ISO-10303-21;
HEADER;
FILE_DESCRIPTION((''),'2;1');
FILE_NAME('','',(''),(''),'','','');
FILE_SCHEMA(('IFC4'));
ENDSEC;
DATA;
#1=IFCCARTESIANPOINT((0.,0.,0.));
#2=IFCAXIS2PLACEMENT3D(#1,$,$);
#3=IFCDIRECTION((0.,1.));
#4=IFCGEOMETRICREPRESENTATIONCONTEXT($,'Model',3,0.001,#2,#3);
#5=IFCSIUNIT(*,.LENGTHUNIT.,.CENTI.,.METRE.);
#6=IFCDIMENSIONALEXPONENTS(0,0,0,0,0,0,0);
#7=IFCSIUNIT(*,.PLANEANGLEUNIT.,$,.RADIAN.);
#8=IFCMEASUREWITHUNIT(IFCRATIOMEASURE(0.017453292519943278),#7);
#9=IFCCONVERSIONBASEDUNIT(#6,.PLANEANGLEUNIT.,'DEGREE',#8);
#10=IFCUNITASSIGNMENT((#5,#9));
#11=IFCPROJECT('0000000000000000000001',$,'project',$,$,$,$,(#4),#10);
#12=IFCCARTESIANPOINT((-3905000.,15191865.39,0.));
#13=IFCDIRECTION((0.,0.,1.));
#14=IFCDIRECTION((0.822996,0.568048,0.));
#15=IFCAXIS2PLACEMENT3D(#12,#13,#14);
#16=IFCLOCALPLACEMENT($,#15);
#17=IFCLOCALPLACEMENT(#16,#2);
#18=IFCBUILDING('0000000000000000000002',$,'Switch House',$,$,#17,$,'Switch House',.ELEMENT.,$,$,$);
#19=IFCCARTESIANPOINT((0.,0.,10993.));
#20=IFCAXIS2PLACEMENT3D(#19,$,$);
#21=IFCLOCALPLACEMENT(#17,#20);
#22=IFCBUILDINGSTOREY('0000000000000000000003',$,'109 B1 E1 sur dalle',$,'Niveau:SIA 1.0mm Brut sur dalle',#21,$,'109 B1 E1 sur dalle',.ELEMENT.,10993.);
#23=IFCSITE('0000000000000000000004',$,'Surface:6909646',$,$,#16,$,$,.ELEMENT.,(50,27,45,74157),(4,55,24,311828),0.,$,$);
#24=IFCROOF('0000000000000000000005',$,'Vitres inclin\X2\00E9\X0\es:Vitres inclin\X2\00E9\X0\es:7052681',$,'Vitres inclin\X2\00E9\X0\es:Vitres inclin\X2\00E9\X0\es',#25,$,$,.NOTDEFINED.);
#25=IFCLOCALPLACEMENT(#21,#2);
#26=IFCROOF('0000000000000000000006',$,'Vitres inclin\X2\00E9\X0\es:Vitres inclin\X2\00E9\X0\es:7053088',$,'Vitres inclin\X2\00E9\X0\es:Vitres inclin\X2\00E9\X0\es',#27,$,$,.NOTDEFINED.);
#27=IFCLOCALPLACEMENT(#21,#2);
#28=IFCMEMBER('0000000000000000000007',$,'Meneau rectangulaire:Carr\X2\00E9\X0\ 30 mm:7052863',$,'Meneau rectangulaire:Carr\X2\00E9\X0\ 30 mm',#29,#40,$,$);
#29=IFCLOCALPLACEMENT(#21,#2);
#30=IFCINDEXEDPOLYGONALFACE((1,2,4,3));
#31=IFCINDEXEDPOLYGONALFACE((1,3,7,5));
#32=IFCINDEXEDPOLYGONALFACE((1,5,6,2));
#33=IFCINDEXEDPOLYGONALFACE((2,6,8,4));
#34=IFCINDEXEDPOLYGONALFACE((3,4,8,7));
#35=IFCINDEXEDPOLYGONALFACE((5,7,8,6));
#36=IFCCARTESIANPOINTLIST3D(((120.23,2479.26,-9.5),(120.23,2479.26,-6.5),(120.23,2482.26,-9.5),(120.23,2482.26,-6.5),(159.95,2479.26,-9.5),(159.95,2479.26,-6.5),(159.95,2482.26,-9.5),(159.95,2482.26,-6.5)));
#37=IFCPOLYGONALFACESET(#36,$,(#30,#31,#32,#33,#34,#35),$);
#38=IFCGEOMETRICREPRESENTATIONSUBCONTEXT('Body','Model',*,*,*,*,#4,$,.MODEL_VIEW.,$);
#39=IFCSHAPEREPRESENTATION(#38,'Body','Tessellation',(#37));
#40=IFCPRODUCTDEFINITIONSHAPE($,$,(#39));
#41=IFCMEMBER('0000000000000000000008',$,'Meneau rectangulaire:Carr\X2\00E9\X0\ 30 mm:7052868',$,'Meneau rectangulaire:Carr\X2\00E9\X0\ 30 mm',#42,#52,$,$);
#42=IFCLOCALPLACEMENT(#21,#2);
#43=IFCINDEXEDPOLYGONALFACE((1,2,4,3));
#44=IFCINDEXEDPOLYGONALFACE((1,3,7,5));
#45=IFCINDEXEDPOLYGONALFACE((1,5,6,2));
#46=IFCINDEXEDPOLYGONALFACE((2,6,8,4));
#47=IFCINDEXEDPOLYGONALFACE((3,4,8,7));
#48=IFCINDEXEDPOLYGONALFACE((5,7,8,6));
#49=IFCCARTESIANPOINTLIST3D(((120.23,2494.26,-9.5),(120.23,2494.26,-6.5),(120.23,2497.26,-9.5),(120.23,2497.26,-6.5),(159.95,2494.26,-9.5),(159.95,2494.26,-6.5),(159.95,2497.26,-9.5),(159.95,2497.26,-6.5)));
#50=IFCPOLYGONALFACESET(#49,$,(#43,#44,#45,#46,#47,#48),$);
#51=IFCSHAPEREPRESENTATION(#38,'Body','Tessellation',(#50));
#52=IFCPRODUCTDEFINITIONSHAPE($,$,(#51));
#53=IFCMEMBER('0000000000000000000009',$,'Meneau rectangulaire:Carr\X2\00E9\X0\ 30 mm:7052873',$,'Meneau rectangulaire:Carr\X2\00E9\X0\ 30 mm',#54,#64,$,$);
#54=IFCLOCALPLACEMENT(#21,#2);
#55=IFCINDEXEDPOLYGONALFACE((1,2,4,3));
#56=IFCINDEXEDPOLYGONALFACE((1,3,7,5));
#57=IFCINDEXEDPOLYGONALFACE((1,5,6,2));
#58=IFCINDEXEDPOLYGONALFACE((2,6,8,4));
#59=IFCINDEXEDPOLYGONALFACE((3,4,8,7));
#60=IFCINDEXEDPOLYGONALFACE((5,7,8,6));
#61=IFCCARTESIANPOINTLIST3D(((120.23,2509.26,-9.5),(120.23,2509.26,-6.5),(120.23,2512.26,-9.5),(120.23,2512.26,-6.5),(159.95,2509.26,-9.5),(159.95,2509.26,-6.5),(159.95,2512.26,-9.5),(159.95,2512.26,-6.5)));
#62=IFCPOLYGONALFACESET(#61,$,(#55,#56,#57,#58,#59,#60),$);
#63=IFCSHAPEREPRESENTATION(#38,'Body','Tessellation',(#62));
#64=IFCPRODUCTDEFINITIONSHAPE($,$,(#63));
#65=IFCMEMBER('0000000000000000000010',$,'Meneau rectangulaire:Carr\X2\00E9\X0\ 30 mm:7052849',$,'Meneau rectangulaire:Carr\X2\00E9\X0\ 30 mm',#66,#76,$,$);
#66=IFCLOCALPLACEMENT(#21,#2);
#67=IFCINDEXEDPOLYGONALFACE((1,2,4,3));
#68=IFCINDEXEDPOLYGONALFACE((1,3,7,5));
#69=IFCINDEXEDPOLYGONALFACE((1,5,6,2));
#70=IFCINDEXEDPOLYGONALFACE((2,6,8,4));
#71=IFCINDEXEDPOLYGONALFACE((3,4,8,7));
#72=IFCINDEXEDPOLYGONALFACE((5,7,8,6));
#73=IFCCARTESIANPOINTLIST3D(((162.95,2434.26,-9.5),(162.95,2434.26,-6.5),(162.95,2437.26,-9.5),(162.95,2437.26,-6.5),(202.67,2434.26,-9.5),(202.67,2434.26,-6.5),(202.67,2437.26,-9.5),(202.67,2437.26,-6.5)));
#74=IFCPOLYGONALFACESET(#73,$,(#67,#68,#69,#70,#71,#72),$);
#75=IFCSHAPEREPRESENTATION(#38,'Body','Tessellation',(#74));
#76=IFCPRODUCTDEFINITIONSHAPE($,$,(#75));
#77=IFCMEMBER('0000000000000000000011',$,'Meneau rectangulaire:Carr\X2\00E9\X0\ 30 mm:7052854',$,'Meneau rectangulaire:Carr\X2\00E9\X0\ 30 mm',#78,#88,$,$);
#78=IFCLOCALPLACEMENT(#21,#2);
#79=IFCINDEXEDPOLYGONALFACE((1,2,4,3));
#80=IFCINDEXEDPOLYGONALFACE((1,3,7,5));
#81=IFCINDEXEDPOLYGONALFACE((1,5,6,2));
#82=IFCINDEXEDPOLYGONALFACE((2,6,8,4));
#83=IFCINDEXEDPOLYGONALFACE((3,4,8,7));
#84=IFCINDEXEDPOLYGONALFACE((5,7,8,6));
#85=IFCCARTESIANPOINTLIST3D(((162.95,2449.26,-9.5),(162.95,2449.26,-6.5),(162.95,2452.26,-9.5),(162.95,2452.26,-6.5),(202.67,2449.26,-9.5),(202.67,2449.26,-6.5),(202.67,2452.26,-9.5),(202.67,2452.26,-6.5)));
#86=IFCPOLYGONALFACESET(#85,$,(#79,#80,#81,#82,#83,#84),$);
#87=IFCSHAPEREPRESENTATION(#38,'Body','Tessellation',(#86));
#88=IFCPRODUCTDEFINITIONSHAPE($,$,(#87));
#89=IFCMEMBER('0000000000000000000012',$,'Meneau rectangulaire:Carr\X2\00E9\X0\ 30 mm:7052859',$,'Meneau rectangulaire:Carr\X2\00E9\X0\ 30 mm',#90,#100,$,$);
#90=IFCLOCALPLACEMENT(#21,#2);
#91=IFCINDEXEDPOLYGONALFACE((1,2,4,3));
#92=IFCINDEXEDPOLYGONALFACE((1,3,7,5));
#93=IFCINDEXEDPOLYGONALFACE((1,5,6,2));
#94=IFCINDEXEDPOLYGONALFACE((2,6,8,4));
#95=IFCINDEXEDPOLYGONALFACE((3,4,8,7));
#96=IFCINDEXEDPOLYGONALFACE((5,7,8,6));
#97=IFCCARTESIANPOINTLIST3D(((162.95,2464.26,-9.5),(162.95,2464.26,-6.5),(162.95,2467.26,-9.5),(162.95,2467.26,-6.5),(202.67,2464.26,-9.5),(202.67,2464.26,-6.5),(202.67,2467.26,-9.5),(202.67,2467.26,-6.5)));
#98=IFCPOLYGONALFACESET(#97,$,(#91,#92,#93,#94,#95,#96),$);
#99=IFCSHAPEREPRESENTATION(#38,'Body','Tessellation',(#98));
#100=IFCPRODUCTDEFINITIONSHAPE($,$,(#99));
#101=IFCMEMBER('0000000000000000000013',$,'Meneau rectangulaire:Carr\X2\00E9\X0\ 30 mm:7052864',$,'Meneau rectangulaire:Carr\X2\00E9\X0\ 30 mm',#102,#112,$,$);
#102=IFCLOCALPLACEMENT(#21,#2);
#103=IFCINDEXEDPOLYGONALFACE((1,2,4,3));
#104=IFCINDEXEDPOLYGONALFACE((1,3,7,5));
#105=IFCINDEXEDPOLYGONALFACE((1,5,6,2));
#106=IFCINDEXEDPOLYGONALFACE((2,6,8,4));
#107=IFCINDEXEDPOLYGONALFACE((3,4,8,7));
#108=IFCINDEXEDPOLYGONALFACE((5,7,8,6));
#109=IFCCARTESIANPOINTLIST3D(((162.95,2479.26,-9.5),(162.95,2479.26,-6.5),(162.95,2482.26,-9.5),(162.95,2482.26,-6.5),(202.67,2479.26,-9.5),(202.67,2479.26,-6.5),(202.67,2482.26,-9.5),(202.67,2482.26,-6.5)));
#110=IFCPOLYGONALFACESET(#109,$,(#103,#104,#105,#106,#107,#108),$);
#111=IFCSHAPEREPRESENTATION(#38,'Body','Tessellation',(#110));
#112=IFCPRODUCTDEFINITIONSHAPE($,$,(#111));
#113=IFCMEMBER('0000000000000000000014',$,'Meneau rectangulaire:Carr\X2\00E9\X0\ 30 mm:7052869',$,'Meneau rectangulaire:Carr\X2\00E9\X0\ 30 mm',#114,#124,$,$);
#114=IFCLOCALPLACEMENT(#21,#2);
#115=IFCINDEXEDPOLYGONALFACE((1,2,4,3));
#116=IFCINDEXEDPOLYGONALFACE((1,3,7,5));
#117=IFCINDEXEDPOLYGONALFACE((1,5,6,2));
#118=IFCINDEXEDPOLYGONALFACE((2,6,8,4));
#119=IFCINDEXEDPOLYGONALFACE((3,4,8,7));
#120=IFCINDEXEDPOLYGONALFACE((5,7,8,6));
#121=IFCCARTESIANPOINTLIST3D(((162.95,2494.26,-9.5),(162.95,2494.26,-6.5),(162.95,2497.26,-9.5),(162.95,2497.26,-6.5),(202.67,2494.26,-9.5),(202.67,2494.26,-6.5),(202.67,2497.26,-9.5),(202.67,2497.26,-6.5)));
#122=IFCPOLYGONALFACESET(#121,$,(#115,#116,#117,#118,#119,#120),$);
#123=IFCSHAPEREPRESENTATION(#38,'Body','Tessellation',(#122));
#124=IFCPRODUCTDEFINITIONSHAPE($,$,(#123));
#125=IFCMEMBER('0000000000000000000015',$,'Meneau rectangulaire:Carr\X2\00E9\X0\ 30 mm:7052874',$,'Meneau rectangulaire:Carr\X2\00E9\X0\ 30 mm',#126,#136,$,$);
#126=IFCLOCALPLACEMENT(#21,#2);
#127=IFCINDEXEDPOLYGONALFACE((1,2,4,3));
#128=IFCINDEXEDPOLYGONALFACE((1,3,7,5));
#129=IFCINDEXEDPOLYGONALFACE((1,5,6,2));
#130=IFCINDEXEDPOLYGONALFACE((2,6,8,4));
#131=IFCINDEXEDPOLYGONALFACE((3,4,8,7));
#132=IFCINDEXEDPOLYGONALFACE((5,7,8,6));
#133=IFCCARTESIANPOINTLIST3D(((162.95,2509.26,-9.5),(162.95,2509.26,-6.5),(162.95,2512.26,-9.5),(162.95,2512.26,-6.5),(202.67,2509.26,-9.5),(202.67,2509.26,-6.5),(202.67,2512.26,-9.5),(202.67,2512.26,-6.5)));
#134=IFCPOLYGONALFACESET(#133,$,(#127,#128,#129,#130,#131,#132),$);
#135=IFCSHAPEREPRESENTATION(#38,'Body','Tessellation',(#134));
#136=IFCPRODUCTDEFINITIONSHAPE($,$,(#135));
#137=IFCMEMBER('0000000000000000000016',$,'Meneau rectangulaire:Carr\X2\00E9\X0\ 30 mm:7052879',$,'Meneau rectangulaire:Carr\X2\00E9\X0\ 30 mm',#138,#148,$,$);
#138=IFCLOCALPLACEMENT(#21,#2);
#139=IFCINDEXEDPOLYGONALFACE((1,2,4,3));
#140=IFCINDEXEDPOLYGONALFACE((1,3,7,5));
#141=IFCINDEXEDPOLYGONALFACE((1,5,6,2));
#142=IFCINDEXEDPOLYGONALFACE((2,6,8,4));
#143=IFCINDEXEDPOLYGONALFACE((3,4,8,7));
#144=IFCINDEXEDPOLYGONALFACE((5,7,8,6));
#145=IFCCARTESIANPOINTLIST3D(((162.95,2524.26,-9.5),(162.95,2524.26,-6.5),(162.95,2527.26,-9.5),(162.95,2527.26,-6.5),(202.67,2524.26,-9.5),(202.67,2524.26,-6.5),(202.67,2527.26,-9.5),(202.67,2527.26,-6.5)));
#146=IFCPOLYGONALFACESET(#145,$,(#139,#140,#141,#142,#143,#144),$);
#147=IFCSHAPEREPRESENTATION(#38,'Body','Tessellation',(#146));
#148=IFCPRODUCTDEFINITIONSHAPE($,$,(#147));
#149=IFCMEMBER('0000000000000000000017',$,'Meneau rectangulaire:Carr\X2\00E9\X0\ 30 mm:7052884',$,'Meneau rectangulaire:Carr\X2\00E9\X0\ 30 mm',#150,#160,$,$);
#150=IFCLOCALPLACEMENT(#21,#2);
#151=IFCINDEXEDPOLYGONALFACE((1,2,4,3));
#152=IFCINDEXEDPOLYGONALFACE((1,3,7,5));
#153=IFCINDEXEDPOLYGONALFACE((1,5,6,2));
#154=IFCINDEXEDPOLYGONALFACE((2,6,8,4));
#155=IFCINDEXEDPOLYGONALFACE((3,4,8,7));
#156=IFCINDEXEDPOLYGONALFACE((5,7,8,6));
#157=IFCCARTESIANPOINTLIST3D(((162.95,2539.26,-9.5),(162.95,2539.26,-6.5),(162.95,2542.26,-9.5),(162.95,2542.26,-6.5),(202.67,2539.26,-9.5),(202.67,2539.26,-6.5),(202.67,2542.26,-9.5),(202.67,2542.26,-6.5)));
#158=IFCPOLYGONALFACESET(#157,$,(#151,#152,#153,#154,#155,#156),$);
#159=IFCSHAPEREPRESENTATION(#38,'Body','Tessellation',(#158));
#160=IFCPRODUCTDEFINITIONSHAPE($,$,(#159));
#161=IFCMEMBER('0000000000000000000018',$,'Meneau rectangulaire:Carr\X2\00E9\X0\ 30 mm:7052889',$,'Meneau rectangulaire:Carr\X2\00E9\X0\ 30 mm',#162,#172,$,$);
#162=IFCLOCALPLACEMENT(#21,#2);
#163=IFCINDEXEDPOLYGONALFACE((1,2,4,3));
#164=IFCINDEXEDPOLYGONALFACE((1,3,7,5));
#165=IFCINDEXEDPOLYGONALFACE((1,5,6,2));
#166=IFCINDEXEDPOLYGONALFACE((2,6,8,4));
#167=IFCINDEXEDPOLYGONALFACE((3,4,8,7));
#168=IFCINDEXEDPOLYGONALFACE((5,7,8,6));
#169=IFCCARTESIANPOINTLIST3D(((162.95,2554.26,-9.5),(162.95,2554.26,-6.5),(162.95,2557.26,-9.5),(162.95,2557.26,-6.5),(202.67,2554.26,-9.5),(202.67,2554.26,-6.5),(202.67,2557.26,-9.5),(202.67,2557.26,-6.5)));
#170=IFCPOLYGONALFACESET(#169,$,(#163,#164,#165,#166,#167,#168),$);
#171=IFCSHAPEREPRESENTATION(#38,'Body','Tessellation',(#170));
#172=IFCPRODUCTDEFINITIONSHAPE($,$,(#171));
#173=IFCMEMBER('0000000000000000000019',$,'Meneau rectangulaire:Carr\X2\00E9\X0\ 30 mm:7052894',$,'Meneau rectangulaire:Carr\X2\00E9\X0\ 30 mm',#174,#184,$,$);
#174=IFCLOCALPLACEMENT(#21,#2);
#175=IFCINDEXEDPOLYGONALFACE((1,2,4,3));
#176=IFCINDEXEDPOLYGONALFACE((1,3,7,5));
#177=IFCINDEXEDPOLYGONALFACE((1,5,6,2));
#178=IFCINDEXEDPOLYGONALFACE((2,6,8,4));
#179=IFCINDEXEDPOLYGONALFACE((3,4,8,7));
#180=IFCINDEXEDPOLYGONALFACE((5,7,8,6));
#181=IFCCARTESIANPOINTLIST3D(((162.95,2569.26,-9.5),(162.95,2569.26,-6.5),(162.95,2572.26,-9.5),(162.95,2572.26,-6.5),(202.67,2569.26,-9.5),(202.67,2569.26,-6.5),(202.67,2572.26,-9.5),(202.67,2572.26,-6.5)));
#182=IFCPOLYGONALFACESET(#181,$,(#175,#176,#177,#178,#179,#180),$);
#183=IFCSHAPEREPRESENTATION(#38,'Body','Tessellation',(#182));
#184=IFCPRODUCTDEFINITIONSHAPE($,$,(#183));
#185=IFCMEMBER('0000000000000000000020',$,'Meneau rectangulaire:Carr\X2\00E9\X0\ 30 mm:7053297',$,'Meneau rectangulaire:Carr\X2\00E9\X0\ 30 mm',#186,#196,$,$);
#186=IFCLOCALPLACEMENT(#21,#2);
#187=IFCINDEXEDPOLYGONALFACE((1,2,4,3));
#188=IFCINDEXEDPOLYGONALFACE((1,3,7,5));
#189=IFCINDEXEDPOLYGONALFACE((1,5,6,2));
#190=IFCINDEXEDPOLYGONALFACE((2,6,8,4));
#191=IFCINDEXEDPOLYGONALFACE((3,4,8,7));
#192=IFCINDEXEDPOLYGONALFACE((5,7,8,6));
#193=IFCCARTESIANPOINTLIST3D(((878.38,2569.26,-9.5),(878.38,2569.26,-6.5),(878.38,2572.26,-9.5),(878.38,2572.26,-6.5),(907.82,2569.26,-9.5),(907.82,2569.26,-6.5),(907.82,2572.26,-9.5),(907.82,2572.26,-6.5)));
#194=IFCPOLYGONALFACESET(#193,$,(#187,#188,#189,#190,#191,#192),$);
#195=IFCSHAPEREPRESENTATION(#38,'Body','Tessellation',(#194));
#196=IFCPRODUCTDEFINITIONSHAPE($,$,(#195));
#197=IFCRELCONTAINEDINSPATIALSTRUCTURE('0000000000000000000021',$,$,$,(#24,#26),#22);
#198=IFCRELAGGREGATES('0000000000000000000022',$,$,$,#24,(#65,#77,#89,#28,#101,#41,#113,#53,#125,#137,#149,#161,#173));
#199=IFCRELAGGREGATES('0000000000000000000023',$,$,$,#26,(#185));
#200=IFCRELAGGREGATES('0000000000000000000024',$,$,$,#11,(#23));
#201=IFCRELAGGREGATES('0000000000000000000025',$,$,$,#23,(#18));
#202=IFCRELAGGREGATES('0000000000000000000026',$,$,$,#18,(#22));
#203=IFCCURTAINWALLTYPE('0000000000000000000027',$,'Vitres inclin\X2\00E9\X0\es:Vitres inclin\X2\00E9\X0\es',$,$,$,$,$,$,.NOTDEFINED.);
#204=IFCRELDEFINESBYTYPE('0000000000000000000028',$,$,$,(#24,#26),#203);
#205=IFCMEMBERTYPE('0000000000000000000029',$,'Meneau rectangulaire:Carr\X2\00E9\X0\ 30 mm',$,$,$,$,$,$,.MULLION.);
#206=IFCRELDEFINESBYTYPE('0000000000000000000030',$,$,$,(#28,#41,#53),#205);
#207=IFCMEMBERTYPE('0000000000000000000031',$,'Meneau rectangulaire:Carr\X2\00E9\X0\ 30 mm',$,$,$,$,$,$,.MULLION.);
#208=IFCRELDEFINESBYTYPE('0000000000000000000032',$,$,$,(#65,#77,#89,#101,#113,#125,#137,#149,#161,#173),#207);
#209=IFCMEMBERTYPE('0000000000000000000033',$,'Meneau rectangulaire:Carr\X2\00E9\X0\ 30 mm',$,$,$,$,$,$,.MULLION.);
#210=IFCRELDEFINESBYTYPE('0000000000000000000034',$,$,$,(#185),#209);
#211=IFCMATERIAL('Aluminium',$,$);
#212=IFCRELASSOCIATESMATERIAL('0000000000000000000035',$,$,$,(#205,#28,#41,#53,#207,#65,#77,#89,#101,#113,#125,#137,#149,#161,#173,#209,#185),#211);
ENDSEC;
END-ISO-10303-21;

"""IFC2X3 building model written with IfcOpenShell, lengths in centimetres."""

from ifc_helpers import new_model, entity, si_unit, converted_unit, direction, frame, origin, origin_2d_with_axis, place, context, subcontext, project, spatial, rectangle, extrude, source, transform, mapped, material, type_object, type_shapes, element, aggregate, save


model = new_model("IFC2X3")

# Units and contexts
model_context = context("Model", 3, precision=0.001, world=origin(), true_north=direction((0.0, 1.0)))
body_context = subcontext(model_context, "Body", "Model", "MODEL_VIEW")
ifc_project = project(units=[si_unit("LENGTHUNIT", "METRE", prefix="CENTI"), converted_unit("PLANEANGLEUNIT", "DEGREE", entity("IfcRatioMeasure", 0.017453292519943278), si_unit("PLANEANGLEUNIT", "RADIAN"), dimensions=[0, 0, 0, 0, 0, 0, 0])], contexts=[model_context])

# Site, building, storey
site_placement = place(None, frame((-3905000.0, 15191865.39, 0.0), z_axis=(0.0, 0.0, 1.0), x_axis=(0.822996, 0.568048, 0.0)))
site = spatial("IfcSite", under=ifc_project, at=site_placement, Name="Surface:6909646", CompositionType="ELEMENT", RefLatitude=(50, 27, 45, 74157), RefLongitude=(4, 55, 24, 311828), RefElevation=0.0)
building_placement = place(site_placement, origin())
building = spatial("IfcBuilding", under=site, at=building_placement, Name="Switch House", LongName="Switch House", CompositionType="ELEMENT")
storey_placement = place(building_placement, frame((0.0, 0.0, 10993.0)))
storey = spatial("IfcBuildingStorey", under=building, at=storey_placement, Name="109 B1 E1 sur dalle", ObjectType="Niveau:SIA 1.0mm Brut sur dalle", LongName="109 B1 E1 sur dalle", CompositionType="ELEMENT", Elevation=10993.0)

# Roofs
curtain_wall_type = type_object("IfcCurtainWallType", Name="Vitres inclinées:Vitres inclinées", PredefinedType="NOTDEFINED")
roof_1_placement = place(storey_placement, frame((0.0, 0.0, -10993.0)))
roof_1 = element("IfcRoof", 1, at=roof_1_placement, inside=storey, type_object=curtain_wall_type, Name="Vitres inclinées:Vitres inclinées:7052681", ObjectType="Vitres inclinées:Vitres inclinées", ShapeType="NOTDEFINED")
ifc_material = material(Name="Aluminium")
roof_2_placement = place(storey_placement, frame((0.0, 0.0, -10993.0)))
roof_2 = element("IfcRoof", 2, at=roof_2_placement, inside=storey, type_object=curtain_wall_type, Name="Vitres inclinées:Vitres inclinées:7053088", ObjectType="Vitres inclinées:Vitres inclinées", ShapeType="NOTDEFINED")

# Members
member_type_1 = type_object("IfcMemberType", Name="Meneau rectangulaire:Carré 30 mm", PredefinedType="MULLION", material=ifc_material)
shared_shape_1 = source(origin(), body_context, "Body", "SweptSolid", [
    extrude(rectangle(XDim=3.0, YDim=3.0, at=origin_2d_with_axis()), frame((0.0, 0.0, -39.72), z_axis=(0.0, 0.0, 1.0), x_axis=(0.0, -1.0, 0.0)), (0.0, 0.0, 1.0), 39.72),
])
type_shapes(member_type_1, [shared_shape_1])
member_1_placement = place(roof_1_placement, frame((120.23, 2480.76, 10985.0), z_axis=(-1.0, 0.0, 0.0), x_axis=(0.0, 1.0, 0.0)))
member_1 = element("IfcMember", 3, at=member_1_placement, type_object=member_type_1, material=ifc_material, Name="Meneau rectangulaire:Carré 30 mm:7052863", ObjectType="Meneau rectangulaire:Carré 30 mm", context=body_context, shape_type="MappedRepresentation", body=[
    mapped(shared_shape_1, transform((0.0, 0.0, 0.0), scale=1.0)),
])
member_2_placement = place(roof_1_placement, frame((120.23, 2495.76, 10985.0), z_axis=(-1.0, 0.0, 0.0), x_axis=(0.0, 1.0, 0.0)))
member_2 = element("IfcMember", 4, at=member_2_placement, type_object=member_type_1, material=ifc_material, Name="Meneau rectangulaire:Carré 30 mm:7052868", ObjectType="Meneau rectangulaire:Carré 30 mm", context=body_context, shape_type="MappedRepresentation", body=[
    mapped(shared_shape_1, transform((0.0, 0.0, 0.0), scale=1.0)),
])
member_3_placement = place(roof_1_placement, frame((120.23, 2510.76, 10985.0), z_axis=(-1.0, 0.0, 0.0), x_axis=(0.0, 1.0, 0.0)))
member_3 = element("IfcMember", 5, at=member_3_placement, type_object=member_type_1, material=ifc_material, Name="Meneau rectangulaire:Carré 30 mm:7052873", ObjectType="Meneau rectangulaire:Carré 30 mm", context=body_context, shape_type="MappedRepresentation", body=[
    mapped(shared_shape_1, transform((0.0, 0.0, 0.0), scale=1.0)),
])
member_type_2 = type_object("IfcMemberType", Name="Meneau rectangulaire:Carré 30 mm", PredefinedType="MULLION", material=ifc_material)
shared_shape_2 = source(origin(), body_context, "Body", "SweptSolid", [
    extrude(rectangle(XDim=3.0, YDim=3.0, at=origin_2d_with_axis()), frame((0.0, 0.0, -39.72), z_axis=(0.0, 0.0, 1.0), x_axis=(0.0, -1.0, 0.0)), (0.0, 0.0, 1.0), 39.72),
])
type_shapes(member_type_2, [shared_shape_2])
member_4_placement = place(roof_1_placement, frame((162.95, 2435.76, 10985.0), z_axis=(-1.0, 0.0, 0.0), x_axis=(0.0, 1.0, 0.0)))
member_4 = element("IfcMember", 6, at=member_4_placement, type_object=member_type_2, material=ifc_material, Name="Meneau rectangulaire:Carré 30 mm:7052849", ObjectType="Meneau rectangulaire:Carré 30 mm", context=body_context, shape_type="MappedRepresentation", body=[
    mapped(shared_shape_2, transform((0.0, 0.0, 0.0), scale=1.0)),
])
member_5_placement = place(roof_1_placement, frame((162.95, 2450.76, 10985.0), z_axis=(-1.0, 0.0, 0.0), x_axis=(0.0, 1.0, 0.0)))
member_5 = element("IfcMember", 7, at=member_5_placement, type_object=member_type_2, material=ifc_material, Name="Meneau rectangulaire:Carré 30 mm:7052854", ObjectType="Meneau rectangulaire:Carré 30 mm", context=body_context, shape_type="MappedRepresentation", body=[
    mapped(shared_shape_2, transform((0.0, 0.0, 0.0), scale=1.0)),
])
member_6_placement = place(roof_1_placement, frame((162.95, 2465.76, 10985.0), z_axis=(-1.0, 0.0, 0.0), x_axis=(0.0, 1.0, 0.0)))
member_6 = element("IfcMember", 8, at=member_6_placement, type_object=member_type_2, material=ifc_material, Name="Meneau rectangulaire:Carré 30 mm:7052859", ObjectType="Meneau rectangulaire:Carré 30 mm", context=body_context, shape_type="MappedRepresentation", body=[
    mapped(shared_shape_2, transform((0.0, 0.0, 0.0), scale=1.0)),
])
member_7_placement = place(roof_1_placement, frame((162.95, 2480.76, 10985.0), z_axis=(-1.0, 0.0, 0.0), x_axis=(0.0, 1.0, 0.0)))
member_7 = element("IfcMember", 9, at=member_7_placement, type_object=member_type_2, material=ifc_material, Name="Meneau rectangulaire:Carré 30 mm:7052864", ObjectType="Meneau rectangulaire:Carré 30 mm", context=body_context, shape_type="MappedRepresentation", body=[
    mapped(shared_shape_2, transform((0.0, 0.0, 0.0), scale=1.0)),
])
member_8_placement = place(roof_1_placement, frame((162.95, 2495.76, 10985.0), z_axis=(-1.0, 0.0, 0.0), x_axis=(0.0, 1.0, 0.0)))
member_8 = element("IfcMember", 10, at=member_8_placement, type_object=member_type_2, material=ifc_material, Name="Meneau rectangulaire:Carré 30 mm:7052869", ObjectType="Meneau rectangulaire:Carré 30 mm", context=body_context, shape_type="MappedRepresentation", body=[
    mapped(shared_shape_2, transform((0.0, 0.0, 0.0), scale=1.0)),
])
member_9_placement = place(roof_1_placement, frame((162.95, 2510.76, 10985.0), z_axis=(-1.0, 0.0, 0.0), x_axis=(0.0, 1.0, 0.0)))
member_9 = element("IfcMember", 11, at=member_9_placement, type_object=member_type_2, material=ifc_material, Name="Meneau rectangulaire:Carré 30 mm:7052874", ObjectType="Meneau rectangulaire:Carré 30 mm", context=body_context, shape_type="MappedRepresentation", body=[
    mapped(shared_shape_2, transform((0.0, 0.0, 0.0), scale=1.0)),
])
member_10_placement = place(roof_1_placement, frame((162.95, 2525.76, 10985.0), z_axis=(-1.0, 0.0, 0.0), x_axis=(0.0, 1.0, 0.0)))
member_10 = element("IfcMember", 12, at=member_10_placement, type_object=member_type_2, material=ifc_material, Name="Meneau rectangulaire:Carré 30 mm:7052879", ObjectType="Meneau rectangulaire:Carré 30 mm", context=body_context, shape_type="MappedRepresentation", body=[
    mapped(shared_shape_2, transform((0.0, 0.0, 0.0), scale=1.0)),
])
member_11_placement = place(roof_1_placement, frame((162.95, 2540.76, 10985.0), z_axis=(-1.0, 0.0, 0.0), x_axis=(0.0, 1.0, 0.0)))
member_11 = element("IfcMember", 13, at=member_11_placement, type_object=member_type_2, material=ifc_material, Name="Meneau rectangulaire:Carré 30 mm:7052884", ObjectType="Meneau rectangulaire:Carré 30 mm", context=body_context, shape_type="MappedRepresentation", body=[
    mapped(shared_shape_2, transform((0.0, 0.0, 0.0), scale=1.0)),
])
member_12_placement = place(roof_1_placement, frame((162.95, 2555.76, 10985.0), z_axis=(-1.0, 0.0, 0.0), x_axis=(0.0, 1.0, 0.0)))
member_12 = element("IfcMember", 14, at=member_12_placement, type_object=member_type_2, material=ifc_material, Name="Meneau rectangulaire:Carré 30 mm:7052889", ObjectType="Meneau rectangulaire:Carré 30 mm", context=body_context, shape_type="MappedRepresentation", body=[
    mapped(shared_shape_2, transform((0.0, 0.0, 0.0), scale=1.0)),
])
member_13_placement = place(roof_1_placement, frame((162.95, 2570.76, 10985.0), z_axis=(-1.0, 0.0, 0.0), x_axis=(0.0, 1.0, 0.0)))
member_13 = element("IfcMember", 15, at=member_13_placement, type_object=member_type_2, material=ifc_material, Name="Meneau rectangulaire:Carré 30 mm:7052894", ObjectType="Meneau rectangulaire:Carré 30 mm", context=body_context, shape_type="MappedRepresentation", body=[
    mapped(shared_shape_2, transform((0.0, 0.0, 0.0), scale=1.0)),
])
aggregate(roof_1, [member_4, member_5, member_6, member_1, member_7, member_2, member_8, member_3, member_9, member_10, member_11, member_12, member_13])
member_type_3 = type_object("IfcMemberType", Name="Meneau rectangulaire:Carré 30 mm", PredefinedType="MULLION", material=ifc_material)
shared_shape_3 = source(origin(), body_context, "Body", "SweptSolid", [
    extrude(rectangle(XDim=3.0, YDim=3.0, at=origin_2d_with_axis()), frame((0.0, 0.0, -29.44), z_axis=(0.0, 0.0, 1.0), x_axis=(0.0, -1.0, 0.0)), (0.0, 0.0, 1.0), 29.44),
])
type_shapes(member_type_3, [shared_shape_3])
member_14_placement = place(roof_2_placement, frame((878.38, 2570.76, 10985.0), z_axis=(-1.0, 0.0, 0.0), x_axis=(0.0, 1.0, 0.0)))
member_14 = element("IfcMember", 16, at=member_14_placement, type_object=member_type_3, material=ifc_material, Name="Meneau rectangulaire:Carré 30 mm:7053297", ObjectType="Meneau rectangulaire:Carré 30 mm", context=body_context, shape_type="MappedRepresentation", body=[
    mapped(shared_shape_3, transform((0.0, 0.0, 0.0), scale=1.0)),
])
aggregate(roof_2, [member_14])

save(model, "model.ifc")
